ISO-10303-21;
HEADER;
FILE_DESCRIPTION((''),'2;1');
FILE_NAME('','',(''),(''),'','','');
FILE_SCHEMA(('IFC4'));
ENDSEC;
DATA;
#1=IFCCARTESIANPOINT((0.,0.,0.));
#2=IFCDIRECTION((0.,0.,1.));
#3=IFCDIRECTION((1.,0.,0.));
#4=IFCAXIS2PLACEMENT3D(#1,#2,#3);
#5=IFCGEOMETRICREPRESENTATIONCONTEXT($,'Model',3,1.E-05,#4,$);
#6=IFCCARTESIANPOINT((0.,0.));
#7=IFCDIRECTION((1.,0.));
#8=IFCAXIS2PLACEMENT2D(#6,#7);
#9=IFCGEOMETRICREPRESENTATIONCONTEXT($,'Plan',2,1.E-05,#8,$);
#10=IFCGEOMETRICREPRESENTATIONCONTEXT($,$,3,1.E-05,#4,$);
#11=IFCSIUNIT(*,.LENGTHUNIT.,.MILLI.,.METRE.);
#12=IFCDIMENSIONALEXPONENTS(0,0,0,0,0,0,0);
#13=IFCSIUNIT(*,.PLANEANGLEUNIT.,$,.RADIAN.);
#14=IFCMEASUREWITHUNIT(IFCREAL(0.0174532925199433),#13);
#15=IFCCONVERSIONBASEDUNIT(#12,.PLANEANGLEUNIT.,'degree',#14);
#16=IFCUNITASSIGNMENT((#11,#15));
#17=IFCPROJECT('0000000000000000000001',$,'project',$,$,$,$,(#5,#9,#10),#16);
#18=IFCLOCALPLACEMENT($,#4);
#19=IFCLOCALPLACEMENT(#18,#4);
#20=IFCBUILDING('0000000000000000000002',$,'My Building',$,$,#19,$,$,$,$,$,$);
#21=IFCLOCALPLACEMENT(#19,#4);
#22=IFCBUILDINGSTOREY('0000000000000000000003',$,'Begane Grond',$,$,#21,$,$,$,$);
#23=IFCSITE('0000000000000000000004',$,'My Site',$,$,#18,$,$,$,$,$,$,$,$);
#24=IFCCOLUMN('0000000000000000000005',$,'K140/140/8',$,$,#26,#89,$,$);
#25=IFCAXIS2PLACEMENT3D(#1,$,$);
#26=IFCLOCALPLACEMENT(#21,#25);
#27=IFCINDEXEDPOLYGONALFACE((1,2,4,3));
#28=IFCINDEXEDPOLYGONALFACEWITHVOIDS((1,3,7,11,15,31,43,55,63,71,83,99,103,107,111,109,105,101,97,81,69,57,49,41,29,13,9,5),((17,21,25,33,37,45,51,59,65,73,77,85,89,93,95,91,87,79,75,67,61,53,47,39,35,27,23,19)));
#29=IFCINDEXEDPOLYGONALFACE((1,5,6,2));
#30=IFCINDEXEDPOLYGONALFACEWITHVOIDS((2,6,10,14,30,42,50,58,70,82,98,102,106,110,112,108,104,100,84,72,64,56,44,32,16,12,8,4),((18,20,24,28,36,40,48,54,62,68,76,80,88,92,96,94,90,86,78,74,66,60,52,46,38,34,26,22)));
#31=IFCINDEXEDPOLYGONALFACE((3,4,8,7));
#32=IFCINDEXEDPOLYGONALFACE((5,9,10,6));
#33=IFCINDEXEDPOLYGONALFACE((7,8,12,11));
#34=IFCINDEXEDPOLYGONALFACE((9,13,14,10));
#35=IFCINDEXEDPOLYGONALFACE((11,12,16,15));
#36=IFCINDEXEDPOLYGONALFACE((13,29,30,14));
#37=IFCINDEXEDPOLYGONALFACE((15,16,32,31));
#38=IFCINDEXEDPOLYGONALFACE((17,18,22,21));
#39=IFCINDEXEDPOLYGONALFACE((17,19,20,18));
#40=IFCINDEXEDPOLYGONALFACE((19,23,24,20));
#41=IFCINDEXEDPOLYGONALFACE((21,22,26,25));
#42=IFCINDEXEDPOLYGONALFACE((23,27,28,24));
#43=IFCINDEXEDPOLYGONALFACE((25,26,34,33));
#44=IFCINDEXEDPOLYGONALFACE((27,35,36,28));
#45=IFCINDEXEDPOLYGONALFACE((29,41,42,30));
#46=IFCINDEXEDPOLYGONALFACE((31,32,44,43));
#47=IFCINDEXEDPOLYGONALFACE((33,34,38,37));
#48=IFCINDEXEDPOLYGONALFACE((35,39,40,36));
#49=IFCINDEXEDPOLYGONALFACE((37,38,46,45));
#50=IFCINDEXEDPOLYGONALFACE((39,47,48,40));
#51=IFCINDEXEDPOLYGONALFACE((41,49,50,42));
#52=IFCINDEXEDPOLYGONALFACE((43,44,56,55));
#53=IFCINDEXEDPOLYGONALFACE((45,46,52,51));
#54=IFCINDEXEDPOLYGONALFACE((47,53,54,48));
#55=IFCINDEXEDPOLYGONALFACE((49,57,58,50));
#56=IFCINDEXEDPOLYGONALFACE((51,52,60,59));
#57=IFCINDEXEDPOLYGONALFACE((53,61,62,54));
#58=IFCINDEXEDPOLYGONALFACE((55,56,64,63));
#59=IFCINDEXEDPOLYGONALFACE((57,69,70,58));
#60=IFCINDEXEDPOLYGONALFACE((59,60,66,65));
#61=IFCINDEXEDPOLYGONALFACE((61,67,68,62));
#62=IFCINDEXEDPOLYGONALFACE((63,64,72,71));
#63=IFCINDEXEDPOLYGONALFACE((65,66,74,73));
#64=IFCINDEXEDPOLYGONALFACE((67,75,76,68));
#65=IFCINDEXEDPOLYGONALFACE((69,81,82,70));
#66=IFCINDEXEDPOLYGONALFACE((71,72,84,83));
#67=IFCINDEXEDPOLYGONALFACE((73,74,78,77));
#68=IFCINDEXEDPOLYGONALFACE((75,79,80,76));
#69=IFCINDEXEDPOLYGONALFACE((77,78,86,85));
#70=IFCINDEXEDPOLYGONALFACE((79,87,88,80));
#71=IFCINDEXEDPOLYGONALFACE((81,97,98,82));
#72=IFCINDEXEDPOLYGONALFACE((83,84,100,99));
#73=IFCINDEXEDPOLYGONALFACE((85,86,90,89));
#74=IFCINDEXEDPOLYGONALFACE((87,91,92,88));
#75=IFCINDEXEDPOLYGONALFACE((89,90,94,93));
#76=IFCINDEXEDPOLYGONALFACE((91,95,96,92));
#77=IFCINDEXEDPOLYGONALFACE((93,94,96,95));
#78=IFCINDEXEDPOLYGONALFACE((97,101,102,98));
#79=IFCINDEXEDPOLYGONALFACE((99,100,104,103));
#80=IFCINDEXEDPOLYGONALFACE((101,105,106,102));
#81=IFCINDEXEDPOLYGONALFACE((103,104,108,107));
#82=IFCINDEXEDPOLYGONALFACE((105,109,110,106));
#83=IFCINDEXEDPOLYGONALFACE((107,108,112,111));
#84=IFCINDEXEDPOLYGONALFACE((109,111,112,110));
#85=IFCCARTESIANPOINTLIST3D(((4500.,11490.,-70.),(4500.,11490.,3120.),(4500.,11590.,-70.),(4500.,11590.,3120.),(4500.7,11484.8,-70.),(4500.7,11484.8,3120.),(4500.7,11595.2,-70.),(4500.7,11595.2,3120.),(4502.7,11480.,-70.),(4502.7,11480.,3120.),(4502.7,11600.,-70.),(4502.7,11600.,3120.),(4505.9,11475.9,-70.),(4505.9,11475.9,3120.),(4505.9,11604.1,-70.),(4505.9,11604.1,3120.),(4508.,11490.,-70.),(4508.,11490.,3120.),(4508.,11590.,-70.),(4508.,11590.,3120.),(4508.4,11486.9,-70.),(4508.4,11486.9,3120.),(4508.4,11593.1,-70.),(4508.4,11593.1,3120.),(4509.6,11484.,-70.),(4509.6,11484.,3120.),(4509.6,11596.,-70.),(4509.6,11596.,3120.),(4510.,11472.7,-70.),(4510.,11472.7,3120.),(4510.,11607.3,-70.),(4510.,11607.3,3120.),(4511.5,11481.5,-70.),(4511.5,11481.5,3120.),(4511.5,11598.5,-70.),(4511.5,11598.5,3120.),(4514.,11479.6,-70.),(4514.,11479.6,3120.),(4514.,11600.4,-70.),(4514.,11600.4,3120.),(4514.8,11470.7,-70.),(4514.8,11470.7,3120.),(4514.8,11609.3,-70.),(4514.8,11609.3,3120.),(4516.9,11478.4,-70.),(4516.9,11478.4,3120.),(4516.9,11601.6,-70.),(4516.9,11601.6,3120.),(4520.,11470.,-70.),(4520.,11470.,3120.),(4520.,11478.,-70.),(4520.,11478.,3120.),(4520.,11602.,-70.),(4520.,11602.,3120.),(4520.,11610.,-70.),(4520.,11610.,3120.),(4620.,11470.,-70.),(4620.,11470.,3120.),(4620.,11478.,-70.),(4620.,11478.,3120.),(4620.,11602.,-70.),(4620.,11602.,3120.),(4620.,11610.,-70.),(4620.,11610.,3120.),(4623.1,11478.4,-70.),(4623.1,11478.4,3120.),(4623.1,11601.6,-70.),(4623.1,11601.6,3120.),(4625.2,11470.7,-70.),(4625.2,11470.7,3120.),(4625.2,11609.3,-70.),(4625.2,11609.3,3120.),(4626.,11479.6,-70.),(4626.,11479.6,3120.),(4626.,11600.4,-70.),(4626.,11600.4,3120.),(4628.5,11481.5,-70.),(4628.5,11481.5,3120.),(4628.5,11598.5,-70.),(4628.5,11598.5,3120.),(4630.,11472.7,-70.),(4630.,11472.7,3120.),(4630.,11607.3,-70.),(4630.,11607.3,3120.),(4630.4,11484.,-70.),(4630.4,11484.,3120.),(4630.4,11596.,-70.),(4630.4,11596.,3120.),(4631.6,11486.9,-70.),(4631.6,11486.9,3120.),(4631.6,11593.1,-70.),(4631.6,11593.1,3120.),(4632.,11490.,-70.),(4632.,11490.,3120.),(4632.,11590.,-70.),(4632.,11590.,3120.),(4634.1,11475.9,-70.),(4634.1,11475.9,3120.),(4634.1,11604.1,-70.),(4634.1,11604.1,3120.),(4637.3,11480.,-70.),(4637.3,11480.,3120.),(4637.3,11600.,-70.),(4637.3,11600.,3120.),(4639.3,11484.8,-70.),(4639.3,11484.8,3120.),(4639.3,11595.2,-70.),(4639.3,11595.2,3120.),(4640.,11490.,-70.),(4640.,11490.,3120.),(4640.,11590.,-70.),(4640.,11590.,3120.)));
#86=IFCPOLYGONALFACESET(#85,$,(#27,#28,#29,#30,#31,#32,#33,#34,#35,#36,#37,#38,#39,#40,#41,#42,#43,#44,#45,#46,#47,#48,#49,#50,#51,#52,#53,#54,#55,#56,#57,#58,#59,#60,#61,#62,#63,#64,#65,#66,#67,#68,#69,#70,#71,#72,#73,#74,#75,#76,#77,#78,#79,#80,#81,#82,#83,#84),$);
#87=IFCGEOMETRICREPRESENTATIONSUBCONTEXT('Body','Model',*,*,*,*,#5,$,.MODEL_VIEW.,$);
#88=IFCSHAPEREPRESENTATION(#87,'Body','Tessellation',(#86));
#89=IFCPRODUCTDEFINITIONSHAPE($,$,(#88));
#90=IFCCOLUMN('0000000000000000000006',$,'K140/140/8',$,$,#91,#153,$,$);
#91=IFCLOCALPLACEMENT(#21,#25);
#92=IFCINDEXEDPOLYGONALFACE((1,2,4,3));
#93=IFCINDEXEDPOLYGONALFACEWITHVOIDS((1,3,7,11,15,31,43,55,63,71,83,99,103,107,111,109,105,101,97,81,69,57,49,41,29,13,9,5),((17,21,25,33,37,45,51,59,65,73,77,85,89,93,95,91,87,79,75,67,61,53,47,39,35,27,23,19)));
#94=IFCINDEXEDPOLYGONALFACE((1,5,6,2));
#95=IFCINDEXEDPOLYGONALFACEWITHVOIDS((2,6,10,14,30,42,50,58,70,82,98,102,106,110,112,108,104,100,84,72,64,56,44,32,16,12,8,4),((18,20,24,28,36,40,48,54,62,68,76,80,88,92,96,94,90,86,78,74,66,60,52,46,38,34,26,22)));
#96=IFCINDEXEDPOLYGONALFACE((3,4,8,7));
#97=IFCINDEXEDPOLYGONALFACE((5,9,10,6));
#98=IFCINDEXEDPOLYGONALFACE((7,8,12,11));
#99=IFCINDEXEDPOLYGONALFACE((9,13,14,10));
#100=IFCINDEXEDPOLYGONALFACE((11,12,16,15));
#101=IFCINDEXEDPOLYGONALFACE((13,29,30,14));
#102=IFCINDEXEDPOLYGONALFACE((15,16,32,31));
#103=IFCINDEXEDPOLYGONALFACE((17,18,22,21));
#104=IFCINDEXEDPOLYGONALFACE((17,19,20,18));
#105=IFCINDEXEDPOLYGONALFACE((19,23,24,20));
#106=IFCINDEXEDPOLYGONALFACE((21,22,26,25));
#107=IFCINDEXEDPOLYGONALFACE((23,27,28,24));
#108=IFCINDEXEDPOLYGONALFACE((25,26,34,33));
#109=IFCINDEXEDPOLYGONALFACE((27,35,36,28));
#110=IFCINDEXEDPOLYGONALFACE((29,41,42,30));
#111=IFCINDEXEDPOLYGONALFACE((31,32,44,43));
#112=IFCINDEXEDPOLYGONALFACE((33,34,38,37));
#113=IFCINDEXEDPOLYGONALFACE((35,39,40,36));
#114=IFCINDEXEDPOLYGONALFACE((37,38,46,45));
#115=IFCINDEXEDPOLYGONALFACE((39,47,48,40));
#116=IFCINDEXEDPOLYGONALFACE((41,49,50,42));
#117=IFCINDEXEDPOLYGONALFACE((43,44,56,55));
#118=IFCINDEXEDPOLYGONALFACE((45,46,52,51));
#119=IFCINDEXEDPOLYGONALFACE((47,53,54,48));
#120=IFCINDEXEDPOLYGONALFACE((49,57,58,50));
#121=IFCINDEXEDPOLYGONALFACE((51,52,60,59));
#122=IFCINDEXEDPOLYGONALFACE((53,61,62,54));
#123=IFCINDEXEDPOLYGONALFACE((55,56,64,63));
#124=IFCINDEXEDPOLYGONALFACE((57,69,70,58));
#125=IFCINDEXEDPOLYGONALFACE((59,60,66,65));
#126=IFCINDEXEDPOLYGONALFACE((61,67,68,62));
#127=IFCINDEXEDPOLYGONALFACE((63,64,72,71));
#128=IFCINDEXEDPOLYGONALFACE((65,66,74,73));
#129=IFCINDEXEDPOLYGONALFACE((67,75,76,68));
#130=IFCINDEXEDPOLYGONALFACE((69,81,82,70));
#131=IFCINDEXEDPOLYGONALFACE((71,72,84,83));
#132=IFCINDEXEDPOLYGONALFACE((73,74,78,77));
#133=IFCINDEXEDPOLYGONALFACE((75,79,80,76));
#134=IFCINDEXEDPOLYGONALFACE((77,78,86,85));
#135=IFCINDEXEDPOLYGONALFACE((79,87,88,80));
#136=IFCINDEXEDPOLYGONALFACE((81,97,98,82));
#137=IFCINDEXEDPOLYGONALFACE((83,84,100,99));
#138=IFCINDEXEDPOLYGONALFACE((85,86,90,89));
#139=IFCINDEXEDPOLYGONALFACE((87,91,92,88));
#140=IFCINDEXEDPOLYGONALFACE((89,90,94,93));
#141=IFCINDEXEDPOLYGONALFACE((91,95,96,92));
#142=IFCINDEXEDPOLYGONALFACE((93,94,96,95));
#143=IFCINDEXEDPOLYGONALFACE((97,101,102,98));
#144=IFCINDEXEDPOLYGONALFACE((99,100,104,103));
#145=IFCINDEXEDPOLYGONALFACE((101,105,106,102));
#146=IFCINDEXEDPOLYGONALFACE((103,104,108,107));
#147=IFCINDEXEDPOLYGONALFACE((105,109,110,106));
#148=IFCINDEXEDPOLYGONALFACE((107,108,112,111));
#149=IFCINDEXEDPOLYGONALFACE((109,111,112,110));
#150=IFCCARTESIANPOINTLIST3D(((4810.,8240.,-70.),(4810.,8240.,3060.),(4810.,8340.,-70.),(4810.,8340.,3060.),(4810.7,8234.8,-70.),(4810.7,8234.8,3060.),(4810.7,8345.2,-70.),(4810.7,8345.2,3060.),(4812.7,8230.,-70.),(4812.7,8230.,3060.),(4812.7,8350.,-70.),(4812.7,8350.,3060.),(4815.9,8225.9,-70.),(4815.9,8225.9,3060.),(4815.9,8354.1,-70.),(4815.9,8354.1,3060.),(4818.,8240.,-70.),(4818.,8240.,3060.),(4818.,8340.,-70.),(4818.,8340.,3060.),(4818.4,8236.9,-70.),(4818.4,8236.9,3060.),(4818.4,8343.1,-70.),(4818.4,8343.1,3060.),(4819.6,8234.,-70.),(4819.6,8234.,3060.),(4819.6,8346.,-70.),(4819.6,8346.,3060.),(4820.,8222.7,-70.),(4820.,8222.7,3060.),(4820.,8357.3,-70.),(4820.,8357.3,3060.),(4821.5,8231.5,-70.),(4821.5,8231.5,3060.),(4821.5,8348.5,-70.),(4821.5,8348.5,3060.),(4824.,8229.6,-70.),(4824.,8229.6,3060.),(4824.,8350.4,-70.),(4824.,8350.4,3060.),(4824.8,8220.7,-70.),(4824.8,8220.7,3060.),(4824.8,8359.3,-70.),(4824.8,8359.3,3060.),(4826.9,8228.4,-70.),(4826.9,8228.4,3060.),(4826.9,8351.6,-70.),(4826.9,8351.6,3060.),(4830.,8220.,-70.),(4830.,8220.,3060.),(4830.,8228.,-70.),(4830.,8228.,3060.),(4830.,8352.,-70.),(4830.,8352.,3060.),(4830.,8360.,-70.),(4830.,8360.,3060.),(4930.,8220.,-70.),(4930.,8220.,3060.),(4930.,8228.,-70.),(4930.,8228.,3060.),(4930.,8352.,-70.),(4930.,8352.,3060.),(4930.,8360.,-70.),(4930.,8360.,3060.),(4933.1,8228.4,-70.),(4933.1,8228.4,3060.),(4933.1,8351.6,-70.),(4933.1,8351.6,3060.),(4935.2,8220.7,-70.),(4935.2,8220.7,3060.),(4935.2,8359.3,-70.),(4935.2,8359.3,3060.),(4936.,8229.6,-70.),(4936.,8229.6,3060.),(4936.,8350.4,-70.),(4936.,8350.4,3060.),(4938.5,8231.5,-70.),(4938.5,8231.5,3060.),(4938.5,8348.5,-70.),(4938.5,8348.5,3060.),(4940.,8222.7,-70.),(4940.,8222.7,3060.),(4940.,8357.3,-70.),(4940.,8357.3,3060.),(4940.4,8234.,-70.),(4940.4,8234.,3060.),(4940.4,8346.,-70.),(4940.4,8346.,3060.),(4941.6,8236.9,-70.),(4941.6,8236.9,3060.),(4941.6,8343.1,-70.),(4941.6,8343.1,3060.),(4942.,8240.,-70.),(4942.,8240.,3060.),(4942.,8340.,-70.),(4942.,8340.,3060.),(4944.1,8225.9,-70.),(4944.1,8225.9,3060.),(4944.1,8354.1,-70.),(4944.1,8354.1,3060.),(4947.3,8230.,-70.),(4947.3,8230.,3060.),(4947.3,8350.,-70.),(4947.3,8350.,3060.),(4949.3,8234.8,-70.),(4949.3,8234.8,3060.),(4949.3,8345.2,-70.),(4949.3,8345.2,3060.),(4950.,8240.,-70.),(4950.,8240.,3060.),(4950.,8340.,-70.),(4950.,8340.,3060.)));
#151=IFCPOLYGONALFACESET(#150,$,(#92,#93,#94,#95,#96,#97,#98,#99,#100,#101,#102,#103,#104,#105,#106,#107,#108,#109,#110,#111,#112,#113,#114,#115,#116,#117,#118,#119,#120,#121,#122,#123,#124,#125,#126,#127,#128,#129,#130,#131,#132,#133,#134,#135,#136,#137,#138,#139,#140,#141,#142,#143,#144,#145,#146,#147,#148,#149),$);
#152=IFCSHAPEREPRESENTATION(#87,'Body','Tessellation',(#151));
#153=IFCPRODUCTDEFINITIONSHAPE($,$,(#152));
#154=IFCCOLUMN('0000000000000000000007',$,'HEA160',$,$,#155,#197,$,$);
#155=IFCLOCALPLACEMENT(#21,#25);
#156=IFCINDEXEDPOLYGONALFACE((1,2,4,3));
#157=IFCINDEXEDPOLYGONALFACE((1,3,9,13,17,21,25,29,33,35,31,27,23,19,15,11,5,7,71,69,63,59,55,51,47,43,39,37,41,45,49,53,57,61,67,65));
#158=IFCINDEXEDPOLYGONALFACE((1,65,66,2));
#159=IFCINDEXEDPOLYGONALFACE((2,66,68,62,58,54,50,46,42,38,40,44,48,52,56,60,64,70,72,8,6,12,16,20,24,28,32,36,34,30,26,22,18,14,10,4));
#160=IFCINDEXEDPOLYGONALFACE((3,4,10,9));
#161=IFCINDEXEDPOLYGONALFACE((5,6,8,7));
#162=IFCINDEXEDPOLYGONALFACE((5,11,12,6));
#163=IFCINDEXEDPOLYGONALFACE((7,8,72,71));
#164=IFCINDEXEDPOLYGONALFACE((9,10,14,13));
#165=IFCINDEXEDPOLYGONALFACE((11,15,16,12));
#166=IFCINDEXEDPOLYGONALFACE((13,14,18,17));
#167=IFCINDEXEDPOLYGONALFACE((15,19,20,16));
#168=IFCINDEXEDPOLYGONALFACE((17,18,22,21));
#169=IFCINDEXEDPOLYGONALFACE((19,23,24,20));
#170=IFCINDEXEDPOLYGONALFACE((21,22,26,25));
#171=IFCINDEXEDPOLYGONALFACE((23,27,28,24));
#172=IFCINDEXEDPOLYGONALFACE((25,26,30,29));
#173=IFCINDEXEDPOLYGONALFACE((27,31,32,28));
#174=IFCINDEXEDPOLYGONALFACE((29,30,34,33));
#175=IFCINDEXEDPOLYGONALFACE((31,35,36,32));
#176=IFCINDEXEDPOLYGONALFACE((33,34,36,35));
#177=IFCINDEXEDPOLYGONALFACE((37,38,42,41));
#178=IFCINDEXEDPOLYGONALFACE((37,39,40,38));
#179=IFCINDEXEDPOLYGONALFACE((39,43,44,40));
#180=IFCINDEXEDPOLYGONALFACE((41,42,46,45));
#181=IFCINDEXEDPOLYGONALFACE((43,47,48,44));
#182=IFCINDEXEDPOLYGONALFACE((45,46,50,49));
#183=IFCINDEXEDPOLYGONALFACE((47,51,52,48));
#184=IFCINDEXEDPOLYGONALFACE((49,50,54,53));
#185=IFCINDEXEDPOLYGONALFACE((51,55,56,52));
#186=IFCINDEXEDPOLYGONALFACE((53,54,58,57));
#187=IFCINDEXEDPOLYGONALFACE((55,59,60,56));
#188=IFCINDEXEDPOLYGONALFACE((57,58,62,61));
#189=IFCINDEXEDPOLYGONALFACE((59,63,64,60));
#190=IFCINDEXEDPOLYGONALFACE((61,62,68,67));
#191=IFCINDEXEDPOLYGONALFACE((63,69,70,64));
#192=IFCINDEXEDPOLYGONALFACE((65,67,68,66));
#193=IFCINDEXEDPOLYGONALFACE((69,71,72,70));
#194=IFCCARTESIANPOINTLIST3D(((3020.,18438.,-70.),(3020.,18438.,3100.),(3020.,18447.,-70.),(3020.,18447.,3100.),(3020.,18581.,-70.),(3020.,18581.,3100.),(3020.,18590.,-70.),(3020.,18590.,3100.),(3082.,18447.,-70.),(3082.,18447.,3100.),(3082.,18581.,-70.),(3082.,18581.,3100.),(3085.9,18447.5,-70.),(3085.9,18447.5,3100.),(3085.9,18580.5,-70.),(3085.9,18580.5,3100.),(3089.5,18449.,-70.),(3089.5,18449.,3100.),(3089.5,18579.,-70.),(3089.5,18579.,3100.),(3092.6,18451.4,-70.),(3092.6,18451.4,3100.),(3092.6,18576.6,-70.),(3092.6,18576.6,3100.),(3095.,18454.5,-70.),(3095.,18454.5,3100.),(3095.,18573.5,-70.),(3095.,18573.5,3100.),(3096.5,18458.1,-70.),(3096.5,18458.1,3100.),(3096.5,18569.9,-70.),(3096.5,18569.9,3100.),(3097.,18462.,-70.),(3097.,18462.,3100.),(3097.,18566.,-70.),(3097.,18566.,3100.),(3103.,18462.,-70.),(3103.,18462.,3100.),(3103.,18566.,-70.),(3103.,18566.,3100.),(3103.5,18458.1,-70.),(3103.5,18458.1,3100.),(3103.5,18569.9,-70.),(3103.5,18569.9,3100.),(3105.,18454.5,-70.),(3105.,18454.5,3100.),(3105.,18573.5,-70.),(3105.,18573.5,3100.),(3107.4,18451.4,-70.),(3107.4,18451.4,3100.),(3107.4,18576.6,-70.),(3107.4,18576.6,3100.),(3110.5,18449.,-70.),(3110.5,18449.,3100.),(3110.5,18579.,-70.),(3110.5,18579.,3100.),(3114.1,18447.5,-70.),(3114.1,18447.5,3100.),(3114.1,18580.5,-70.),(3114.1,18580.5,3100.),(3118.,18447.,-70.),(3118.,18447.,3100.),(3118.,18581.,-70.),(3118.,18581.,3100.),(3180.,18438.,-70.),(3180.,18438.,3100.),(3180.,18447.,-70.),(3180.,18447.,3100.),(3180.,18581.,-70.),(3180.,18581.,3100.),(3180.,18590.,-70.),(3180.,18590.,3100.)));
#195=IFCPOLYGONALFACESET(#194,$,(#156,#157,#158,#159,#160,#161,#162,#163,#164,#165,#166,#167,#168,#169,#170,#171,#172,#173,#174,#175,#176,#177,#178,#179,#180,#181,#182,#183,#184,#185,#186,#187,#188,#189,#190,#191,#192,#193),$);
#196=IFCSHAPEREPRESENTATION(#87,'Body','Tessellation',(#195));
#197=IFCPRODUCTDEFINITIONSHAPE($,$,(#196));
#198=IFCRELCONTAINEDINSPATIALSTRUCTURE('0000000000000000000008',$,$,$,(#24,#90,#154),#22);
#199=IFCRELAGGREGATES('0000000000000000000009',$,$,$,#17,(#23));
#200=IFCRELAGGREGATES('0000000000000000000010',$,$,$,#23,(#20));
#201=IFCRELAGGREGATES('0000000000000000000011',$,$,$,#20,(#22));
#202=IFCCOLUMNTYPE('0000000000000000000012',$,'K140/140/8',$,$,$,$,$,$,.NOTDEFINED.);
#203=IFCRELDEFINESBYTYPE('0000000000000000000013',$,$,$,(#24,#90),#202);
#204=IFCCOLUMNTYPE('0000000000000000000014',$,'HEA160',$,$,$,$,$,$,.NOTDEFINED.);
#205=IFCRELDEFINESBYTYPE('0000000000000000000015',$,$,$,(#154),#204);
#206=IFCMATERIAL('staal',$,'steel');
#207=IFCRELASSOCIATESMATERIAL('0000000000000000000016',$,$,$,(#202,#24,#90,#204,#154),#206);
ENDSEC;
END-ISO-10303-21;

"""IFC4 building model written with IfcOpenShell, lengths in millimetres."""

from ifc_helpers import new_model, entity, si_unit, converted_unit, frame, origin_with_axes, origin_2d_with_axis, place, context, subcontext, project, spatial, hollow_rectangle, i_section, extrude, material, material_profile, profile_set, profile_usage, type_object, element, save


model = new_model("IFC4")

# Units and contexts
model_context = context("Model", 3, precision=1e-05, world=origin_with_axes())
plan_context = context("Plan", 2, precision=1e-05, world=origin_2d_with_axis())
context_of_model = context(None, 3, precision=1e-05, world=origin_with_axes())
body_context = subcontext(model_context, "Body", "Model", "MODEL_VIEW")
ifc_project = project(units=[si_unit("LENGTHUNIT", "METRE", prefix="MILLI"), converted_unit("PLANEANGLEUNIT", "degree", entity("IfcReal", 0.0174532925199433), si_unit("PLANEANGLEUNIT", "RADIAN"), dimensions=[0, 0, 0, 0, 0, 0, 0])], contexts=[model_context, plan_context, context_of_model])

# Site, building, storey
site_placement = place(None, origin_with_axes())
site = spatial("IfcSite", under=ifc_project, at=site_placement, Name="My Site")
building_placement = place(site_placement, origin_with_axes())
building = spatial("IfcBuilding", under=site, at=building_placement, Name="My Building")
storey_placement = place(building_placement, origin_with_axes())
storey = spatial("IfcBuildingStorey", under=building, at=storey_placement, Name="Begane Grond")

# Columns
ifc_material = material(Name="staal", Category="steel")
ifc_material_profile_1 = material_profile(ifc_material, hollow_rectangle(XDim=140.0, YDim=140.0, WallThickness=8.0, InnerFilletRadius=12.0, OuterFilletRadius=20.0))
ifc_profile_set_1 = profile_set([ifc_material_profile_1], Name="K140/140/8")
ifc_profile_usage_1 = profile_usage(ifc_profile_set_1, cardinal=5)
column_type_1 = type_object("IfcColumnType", Name="K140/140/8", PredefinedType="NOTDEFINED", material=ifc_profile_set_1)
column_1_placement = place(storey_placement, frame((4570.0, 11540.0, -70.0), z_axis=(0.0, 0.0, 1.0), x_axis=(1.0, 0.0, 0.0)))
element("IfcColumn", 1, at=column_1_placement, inside=storey, type_object=column_type_1, material=ifc_profile_usage_1, Name="K140/140/8", context=body_context, shape_type="SweptSolid", body=[
    extrude(hollow_rectangle(XDim=140.0, YDim=140.0, WallThickness=8.0, InnerFilletRadius=12.0, OuterFilletRadius=20.0), origin_with_axes(), (0.0, 0.0, 1.0), 3190.0),
])
ifc_profile_usage_2 = profile_usage(ifc_profile_set_1, cardinal=5)
column_2_placement = place(storey_placement, frame((4880.0, 8290.0, -70.0), z_axis=(0.0, 0.0, 1.0), x_axis=(1.0, 0.0, 0.0)))
element("IfcColumn", 2, at=column_2_placement, inside=storey, type_object=column_type_1, material=ifc_profile_usage_2, Name="K140/140/8", context=body_context, shape_type="SweptSolid", body=[
    extrude(hollow_rectangle(XDim=140.0, YDim=140.0, WallThickness=8.0, InnerFilletRadius=12.0, OuterFilletRadius=20.0), origin_with_axes(), (0.0, 0.0, 1.0), 3130.0),
])
ifc_material_profile_2 = material_profile(ifc_material, i_section(OverallWidth=160.0, OverallDepth=152.0, WebThickness=6.0, FlangeThickness=9.0, FilletRadius=15.0))
ifc_profile_set_2 = profile_set([ifc_material_profile_2], Name="HEA160")
ifc_profile_usage_3 = profile_usage(ifc_profile_set_2)
column_type_2 = type_object("IfcColumnType", Name="HEA160", PredefinedType="NOTDEFINED", material=ifc_profile_set_2)
column_3_placement = place(storey_placement, frame((3100.0, 18514.0, -70.0), z_axis=(0.0, 0.0, 1.0), x_axis=(1.0, 0.0, 0.0)))
element("IfcColumn", 3, at=column_3_placement, inside=storey, type_object=column_type_2, material=ifc_profile_usage_3, Name="HEA160", context=body_context, shape_type="SweptSolid", body=[
    extrude(i_section(OverallWidth=160.0, OverallDepth=152.0, WebThickness=6.0, FlangeThickness=9.0, FilletRadius=15.0), origin_with_axes(), (0.0, 0.0, 1.0), 3170.0),
])

save(model, "model.ifc")
